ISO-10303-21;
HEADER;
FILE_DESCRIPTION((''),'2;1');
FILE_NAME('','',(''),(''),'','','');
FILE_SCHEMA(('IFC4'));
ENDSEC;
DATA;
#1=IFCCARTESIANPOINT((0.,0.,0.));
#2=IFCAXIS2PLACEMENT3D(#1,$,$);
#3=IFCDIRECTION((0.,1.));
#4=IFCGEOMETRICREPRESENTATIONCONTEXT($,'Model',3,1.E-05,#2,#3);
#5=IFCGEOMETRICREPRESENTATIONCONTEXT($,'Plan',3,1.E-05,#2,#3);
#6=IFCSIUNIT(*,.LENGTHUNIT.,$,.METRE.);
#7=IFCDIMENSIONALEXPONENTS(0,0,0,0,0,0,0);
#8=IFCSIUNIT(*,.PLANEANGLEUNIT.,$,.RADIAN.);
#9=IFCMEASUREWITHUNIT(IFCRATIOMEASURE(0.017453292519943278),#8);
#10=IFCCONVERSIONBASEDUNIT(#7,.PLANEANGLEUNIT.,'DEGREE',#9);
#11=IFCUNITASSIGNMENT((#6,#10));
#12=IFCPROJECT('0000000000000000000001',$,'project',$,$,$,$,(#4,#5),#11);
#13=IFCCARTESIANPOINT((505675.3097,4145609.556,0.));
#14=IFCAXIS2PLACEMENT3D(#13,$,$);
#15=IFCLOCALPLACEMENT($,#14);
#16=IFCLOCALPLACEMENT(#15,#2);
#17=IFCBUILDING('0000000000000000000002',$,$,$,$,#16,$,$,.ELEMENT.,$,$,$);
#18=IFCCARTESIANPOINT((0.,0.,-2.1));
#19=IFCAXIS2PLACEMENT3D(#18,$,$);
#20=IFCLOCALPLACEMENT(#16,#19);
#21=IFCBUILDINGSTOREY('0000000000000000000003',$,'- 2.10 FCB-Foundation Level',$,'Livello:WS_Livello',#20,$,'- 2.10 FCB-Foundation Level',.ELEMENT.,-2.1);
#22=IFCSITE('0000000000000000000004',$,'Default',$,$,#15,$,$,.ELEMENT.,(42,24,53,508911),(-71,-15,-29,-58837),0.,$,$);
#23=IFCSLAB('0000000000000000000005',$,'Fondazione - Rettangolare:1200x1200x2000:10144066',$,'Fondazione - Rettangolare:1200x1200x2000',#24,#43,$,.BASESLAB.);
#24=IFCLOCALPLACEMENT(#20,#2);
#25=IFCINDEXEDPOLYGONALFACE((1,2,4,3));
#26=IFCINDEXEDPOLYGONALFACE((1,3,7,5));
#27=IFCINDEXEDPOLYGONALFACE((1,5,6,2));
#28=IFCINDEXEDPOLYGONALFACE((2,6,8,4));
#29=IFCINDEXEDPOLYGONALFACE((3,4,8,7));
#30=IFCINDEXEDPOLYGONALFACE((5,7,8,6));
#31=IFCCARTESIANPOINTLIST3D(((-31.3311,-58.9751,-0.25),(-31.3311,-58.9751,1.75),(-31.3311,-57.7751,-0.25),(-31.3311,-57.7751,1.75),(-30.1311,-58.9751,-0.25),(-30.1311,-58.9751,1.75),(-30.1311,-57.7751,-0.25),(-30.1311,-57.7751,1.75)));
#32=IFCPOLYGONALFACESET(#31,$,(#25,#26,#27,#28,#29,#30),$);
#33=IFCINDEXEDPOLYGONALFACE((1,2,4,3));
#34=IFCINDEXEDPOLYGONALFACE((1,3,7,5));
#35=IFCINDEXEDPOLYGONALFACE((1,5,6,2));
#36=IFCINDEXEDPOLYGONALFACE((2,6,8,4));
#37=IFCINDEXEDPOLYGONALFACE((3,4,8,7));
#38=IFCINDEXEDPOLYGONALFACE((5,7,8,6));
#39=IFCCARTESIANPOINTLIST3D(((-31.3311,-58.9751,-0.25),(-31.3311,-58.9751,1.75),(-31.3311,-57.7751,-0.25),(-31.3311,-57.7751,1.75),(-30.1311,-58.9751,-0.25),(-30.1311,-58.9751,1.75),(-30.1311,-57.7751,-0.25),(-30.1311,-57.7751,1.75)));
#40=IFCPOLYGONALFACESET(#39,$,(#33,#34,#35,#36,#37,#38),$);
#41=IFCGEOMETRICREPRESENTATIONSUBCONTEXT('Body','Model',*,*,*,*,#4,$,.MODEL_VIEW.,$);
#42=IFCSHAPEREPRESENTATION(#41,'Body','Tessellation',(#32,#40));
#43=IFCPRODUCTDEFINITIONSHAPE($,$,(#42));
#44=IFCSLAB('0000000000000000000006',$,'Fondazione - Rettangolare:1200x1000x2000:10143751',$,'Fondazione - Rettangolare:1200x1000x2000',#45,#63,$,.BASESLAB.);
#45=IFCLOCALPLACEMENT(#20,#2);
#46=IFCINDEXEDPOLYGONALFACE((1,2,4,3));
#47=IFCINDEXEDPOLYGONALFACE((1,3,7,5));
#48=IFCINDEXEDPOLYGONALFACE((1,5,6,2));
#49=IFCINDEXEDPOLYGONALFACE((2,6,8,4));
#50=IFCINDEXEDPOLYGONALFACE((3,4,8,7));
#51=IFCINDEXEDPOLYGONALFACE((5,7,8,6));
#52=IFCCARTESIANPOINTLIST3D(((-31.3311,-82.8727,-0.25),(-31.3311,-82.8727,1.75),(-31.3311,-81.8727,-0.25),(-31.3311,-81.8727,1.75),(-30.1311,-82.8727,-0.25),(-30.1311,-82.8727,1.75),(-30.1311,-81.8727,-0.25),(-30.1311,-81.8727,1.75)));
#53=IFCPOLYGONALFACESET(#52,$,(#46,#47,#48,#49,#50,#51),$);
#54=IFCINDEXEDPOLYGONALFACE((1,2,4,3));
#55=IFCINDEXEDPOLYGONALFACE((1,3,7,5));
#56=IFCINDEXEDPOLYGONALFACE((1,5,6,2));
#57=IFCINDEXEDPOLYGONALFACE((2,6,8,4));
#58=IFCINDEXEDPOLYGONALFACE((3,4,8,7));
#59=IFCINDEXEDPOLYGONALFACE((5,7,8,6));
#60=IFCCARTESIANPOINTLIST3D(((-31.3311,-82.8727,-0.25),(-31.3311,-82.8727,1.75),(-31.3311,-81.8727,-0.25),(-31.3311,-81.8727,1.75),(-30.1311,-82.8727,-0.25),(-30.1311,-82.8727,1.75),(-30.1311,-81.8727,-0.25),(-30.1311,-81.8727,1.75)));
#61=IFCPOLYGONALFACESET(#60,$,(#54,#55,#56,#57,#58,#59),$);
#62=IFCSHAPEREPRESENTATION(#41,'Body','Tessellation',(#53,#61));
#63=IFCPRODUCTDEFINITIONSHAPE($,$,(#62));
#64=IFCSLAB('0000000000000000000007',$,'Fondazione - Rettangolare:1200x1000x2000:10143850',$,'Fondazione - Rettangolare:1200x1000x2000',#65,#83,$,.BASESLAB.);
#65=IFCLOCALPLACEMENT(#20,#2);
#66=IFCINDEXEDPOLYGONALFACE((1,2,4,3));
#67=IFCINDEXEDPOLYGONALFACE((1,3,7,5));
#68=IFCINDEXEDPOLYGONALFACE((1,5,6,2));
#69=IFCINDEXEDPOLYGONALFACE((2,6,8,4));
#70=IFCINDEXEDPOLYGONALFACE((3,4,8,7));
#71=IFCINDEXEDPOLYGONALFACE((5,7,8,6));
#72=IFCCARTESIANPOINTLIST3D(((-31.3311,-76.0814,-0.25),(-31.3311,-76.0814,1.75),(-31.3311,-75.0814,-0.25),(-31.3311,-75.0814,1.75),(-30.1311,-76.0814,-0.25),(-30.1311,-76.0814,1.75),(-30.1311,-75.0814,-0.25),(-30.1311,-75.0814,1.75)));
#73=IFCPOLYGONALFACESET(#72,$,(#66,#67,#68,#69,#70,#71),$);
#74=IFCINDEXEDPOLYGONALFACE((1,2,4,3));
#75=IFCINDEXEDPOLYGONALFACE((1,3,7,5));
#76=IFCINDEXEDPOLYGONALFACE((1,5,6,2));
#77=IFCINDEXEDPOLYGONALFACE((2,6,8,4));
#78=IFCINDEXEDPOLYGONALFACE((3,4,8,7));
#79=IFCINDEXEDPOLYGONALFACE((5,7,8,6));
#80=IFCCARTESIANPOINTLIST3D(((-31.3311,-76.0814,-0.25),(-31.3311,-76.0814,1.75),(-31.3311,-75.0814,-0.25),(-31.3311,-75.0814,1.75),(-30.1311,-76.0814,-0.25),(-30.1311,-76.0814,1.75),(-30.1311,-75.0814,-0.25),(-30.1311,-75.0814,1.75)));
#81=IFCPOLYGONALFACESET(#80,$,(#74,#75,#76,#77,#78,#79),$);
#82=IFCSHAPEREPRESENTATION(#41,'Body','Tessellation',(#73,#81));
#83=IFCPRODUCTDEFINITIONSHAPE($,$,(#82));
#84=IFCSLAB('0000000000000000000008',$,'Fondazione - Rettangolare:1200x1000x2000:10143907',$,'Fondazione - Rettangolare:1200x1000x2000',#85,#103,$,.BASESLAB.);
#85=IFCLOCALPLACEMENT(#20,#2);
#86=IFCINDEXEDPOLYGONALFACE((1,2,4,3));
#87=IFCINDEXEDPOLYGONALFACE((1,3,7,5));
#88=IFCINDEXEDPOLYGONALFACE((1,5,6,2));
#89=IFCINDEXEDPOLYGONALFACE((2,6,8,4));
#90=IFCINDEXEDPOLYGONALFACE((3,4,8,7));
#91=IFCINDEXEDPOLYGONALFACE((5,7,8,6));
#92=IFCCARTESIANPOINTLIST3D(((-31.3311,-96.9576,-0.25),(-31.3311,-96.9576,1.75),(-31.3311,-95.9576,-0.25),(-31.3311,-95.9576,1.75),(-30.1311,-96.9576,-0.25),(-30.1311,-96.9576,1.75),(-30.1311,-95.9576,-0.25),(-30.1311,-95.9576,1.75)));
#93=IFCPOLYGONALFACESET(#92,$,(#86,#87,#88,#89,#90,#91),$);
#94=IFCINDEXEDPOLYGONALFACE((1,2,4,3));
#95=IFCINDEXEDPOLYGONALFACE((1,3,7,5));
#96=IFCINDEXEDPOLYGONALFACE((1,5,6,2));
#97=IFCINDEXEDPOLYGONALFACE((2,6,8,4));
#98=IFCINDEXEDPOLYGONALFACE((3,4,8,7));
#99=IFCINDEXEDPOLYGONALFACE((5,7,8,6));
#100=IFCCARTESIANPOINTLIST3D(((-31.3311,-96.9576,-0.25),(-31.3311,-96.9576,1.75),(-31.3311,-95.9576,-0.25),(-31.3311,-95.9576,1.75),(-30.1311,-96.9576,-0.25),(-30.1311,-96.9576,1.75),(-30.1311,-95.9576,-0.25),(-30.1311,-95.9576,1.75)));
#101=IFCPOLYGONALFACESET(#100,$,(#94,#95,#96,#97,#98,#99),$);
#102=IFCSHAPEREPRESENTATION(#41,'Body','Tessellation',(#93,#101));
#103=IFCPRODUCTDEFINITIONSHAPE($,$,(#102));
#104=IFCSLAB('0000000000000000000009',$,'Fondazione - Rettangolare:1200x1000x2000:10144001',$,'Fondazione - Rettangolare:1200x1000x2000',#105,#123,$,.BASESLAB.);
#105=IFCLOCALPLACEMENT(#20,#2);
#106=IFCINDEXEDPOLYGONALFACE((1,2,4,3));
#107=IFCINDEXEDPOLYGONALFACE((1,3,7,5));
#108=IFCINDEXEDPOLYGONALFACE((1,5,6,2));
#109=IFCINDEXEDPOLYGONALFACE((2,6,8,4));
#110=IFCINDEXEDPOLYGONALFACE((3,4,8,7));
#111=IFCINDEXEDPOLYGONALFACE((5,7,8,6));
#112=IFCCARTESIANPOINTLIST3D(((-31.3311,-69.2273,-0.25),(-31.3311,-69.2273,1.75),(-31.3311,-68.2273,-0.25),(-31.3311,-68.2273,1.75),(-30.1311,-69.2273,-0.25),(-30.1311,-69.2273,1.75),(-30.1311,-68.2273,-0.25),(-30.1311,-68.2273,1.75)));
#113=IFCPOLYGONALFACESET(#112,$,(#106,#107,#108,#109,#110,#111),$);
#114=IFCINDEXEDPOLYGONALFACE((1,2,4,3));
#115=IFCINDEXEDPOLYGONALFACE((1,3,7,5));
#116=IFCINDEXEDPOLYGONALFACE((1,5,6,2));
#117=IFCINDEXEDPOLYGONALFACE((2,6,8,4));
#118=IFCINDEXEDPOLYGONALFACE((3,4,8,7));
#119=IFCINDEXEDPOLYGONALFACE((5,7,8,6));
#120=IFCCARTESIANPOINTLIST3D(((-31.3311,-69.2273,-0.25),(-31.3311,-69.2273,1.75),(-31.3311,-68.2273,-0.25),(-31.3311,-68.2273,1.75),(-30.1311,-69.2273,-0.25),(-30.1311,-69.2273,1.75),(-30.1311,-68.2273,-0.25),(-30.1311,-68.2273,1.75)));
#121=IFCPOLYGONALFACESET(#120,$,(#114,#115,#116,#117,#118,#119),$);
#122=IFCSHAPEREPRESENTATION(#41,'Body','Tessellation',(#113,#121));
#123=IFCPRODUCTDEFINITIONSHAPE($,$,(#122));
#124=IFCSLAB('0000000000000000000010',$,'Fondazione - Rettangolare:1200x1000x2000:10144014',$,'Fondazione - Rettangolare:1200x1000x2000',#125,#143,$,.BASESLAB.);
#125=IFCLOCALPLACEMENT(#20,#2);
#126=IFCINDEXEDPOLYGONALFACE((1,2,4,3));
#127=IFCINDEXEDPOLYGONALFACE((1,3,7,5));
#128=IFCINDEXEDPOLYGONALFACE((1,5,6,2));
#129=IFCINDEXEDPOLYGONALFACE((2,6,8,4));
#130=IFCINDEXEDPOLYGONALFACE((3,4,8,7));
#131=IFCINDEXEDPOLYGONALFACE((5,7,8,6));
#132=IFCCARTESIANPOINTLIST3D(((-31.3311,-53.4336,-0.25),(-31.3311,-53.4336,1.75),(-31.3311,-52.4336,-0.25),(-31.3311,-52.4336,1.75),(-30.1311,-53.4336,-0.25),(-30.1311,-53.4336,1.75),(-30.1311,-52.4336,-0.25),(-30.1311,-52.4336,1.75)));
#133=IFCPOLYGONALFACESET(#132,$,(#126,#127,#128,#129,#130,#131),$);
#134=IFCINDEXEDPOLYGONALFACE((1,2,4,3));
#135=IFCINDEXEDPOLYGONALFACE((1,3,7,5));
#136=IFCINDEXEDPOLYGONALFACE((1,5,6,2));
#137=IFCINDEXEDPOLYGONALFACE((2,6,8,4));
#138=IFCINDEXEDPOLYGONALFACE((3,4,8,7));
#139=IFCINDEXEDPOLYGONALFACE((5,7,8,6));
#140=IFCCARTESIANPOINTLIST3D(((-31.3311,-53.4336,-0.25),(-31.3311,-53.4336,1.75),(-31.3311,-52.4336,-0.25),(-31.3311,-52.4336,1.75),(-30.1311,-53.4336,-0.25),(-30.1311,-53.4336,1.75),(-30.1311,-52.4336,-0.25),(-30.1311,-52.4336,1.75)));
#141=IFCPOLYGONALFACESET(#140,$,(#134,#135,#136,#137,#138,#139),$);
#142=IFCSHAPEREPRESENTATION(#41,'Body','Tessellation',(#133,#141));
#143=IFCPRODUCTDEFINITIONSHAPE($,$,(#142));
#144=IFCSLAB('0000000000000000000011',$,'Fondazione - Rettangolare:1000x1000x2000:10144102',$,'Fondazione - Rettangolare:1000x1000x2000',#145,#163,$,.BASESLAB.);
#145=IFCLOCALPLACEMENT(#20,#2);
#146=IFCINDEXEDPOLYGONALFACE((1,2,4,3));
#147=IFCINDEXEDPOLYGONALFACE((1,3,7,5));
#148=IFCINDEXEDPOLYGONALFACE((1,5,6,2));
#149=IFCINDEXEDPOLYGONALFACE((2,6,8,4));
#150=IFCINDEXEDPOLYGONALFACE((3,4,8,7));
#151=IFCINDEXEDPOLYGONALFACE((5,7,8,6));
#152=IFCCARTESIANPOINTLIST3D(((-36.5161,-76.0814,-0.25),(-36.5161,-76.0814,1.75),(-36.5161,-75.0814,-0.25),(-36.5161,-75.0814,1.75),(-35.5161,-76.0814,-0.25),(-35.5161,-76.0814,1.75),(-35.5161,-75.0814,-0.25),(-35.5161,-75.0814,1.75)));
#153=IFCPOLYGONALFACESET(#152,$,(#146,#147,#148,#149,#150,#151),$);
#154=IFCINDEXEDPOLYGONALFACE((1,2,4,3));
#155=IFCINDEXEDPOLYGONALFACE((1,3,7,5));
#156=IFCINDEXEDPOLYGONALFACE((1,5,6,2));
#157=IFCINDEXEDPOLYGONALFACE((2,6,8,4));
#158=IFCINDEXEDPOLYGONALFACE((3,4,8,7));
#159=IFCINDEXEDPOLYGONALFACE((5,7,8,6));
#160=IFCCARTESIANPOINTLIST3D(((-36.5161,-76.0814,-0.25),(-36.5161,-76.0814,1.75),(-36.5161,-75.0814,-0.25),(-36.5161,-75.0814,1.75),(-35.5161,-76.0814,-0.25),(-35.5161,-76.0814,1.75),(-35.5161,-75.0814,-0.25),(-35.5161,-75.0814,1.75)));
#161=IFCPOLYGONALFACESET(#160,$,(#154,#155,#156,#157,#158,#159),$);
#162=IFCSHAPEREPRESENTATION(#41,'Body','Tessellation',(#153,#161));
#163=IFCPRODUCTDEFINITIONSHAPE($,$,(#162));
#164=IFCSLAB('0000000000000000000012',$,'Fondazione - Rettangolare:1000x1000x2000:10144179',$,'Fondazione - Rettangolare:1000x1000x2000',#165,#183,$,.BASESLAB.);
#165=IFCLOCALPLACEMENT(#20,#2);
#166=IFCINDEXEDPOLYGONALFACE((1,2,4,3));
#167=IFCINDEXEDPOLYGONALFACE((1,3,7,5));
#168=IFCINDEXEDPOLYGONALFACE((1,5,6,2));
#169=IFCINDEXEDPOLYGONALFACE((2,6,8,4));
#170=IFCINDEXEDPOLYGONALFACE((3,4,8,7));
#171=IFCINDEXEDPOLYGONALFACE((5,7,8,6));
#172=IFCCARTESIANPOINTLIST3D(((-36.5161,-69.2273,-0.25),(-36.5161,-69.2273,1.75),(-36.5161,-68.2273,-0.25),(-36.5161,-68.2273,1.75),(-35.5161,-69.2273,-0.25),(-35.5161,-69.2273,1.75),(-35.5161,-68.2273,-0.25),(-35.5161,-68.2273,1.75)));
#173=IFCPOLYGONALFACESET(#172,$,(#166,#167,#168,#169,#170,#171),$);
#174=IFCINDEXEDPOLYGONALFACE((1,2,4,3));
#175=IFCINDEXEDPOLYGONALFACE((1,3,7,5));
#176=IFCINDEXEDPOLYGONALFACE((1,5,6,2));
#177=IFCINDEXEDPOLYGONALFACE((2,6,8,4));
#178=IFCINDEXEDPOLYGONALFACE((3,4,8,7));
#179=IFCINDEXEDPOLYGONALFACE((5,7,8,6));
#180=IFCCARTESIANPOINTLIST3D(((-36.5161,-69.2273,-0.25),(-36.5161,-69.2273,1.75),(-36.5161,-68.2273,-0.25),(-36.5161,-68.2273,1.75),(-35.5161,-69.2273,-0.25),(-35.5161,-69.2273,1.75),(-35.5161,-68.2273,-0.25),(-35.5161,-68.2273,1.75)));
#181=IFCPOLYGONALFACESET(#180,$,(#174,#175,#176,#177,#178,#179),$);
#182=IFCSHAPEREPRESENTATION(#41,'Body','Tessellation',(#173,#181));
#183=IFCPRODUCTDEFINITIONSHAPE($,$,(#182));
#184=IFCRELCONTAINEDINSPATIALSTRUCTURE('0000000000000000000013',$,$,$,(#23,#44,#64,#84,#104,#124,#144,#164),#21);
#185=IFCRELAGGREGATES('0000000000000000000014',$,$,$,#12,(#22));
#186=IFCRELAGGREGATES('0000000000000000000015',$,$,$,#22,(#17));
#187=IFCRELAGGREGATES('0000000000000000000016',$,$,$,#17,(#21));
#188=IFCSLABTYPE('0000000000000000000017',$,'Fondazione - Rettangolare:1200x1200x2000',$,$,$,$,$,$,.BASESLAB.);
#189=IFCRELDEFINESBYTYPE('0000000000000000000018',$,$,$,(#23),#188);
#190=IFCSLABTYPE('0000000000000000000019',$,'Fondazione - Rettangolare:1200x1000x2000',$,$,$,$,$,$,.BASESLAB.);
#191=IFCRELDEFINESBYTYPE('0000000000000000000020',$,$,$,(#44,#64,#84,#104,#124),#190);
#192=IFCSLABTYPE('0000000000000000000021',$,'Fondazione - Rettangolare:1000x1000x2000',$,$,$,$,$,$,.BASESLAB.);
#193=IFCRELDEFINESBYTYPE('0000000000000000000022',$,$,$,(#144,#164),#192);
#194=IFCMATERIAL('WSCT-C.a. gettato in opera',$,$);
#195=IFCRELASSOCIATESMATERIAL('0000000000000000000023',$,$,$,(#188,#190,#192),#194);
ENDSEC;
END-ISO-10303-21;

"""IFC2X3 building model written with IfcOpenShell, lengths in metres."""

from ifc_helpers import new_model, entity, si_unit, converted_unit, direction, frame, frame_2d, origin, origin_2d_with_axis, place, context, subcontext, project, spatial, rectangle, extrude, material, type_object, element, save


model = new_model("IFC2X3")

# Units and contexts
model_context = context("Model", 3, precision=1e-05, world=origin(), true_north=direction((0.0, 1.0)))
plan_context = context("Plan", 3, precision=1e-05, world=origin(), true_north=direction((0.0, 1.0)))
body_context = subcontext(model_context, "Body", "Model", "MODEL_VIEW")
ifc_project = project(units=[si_unit("LENGTHUNIT", "METRE"), converted_unit("PLANEANGLEUNIT", "DEGREE", entity("IfcRatioMeasure", 0.017453292519943278), si_unit("PLANEANGLEUNIT", "RADIAN"), dimensions=[0, 0, 0, 0, 0, 0, 0])], contexts=[model_context, plan_context])

# Site, building, storey
site_placement = place(None, frame((505675.3097, 4145609.556, 0.0)))
site = spatial("IfcSite", under=ifc_project, at=site_placement, Name="Default", CompositionType="ELEMENT", RefLatitude=(42, 24, 53, 508911), RefLongitude=(-71, -15, -29, -58837), RefElevation=0.0)
building_placement = place(site_placement, origin())
building = spatial("IfcBuilding", under=site, at=building_placement, CompositionType="ELEMENT")
storey_placement = place(building_placement, frame((0.0, 0.0, -2.1)))
storey = spatial("IfcBuildingStorey", under=building, at=storey_placement, Name="- 2.10 FCB-Foundation Level", ObjectType="Livello:WS_Livello", LongName="- 2.10 FCB-Foundation Level", CompositionType="ELEMENT", Elevation=-2.1)

# Slabs
ifc_material_1 = material(Name="WSCT-C.a. gettato in opera")
slab_type_1 = type_object("IfcSlabType", Name="Fondazione - Rettangolare:1200x1200x2000", PredefinedType="BASESLAB", material=ifc_material_1)
slab_1_placement = place(storey_placement, origin())
element("IfcSlab", 1, at=slab_1_placement, inside=storey, type_object=slab_type_1, Name="Fondazione - Rettangolare:1200x1200x2000:10144066", ObjectType="Fondazione - Rettangolare:1200x1200x2000", PredefinedType="BASESLAB", context=body_context, shape_type="SweptSolid", body=[
    extrude(rectangle(XDim=1.2, YDim=1.2, at=frame_2d((0.0, 0.0), x_axis=(1.0, 0.0))), frame((-30.7311, -58.3751, -0.25), z_axis=(0.0, 0.0, 1.0), x_axis=(-1.0, 0.0, 0.0)), (0.0, 0.0, 1.0), 2.0),
    extrude(rectangle(XDim=1.2, YDim=1.2, at=frame_2d((0.0, 0.0), x_axis=(1.0, 0.0))), frame((-30.7311, -58.3751, -0.25), z_axis=(0.0, 0.0, 1.0), x_axis=(-1.0, 0.0, 0.0)), (0.0, 0.0, 1.0), 2.0),
])
slab_type_2 = type_object("IfcSlabType", Name="Fondazione - Rettangolare:1200x1000x2000", PredefinedType="BASESLAB", material=ifc_material_1)
slab_2_placement = place(storey_placement, origin())
element("IfcSlab", 2, at=slab_2_placement, inside=storey, type_object=slab_type_2, Name="Fondazione - Rettangolare:1200x1000x2000:10143751", ObjectType="Fondazione - Rettangolare:1200x1000x2000", PredefinedType="BASESLAB", context=body_context, shape_type="SweptSolid", body=[
    extrude(rectangle(XDim=1.2, YDim=1.0, at=frame_2d((0.0, 0.0), x_axis=(1.0, 0.0))), frame((-30.7311, -82.3727, -0.25), z_axis=(0.0, 0.0, 1.0), x_axis=(-1.0, 0.0, 0.0)), (0.0, 0.0, 1.0), 2.0),
    extrude(rectangle(XDim=1.2, YDim=1.0, at=frame_2d((0.0, 0.0), x_axis=(1.0, 0.0))), frame((-30.7311, -82.3727, -0.25), z_axis=(0.0, 0.0, 1.0), x_axis=(-1.0, 0.0, 0.0)), (0.0, 0.0, 1.0), 2.0),
])
slab_3_placement = place(storey_placement, origin())
element("IfcSlab", 3, at=slab_3_placement, inside=storey, type_object=slab_type_2, Name="Fondazione - Rettangolare:1200x1000x2000:10143850", ObjectType="Fondazione - Rettangolare:1200x1000x2000", PredefinedType="BASESLAB", context=body_context, shape_type="SweptSolid", body=[
    extrude(rectangle(XDim=1.2, YDim=1.0, at=frame_2d((0.0, 0.0), x_axis=(1.0, 0.0))), frame((-30.7311, -75.5814, -0.25), z_axis=(0.0, 0.0, 1.0), x_axis=(-1.0, 0.0, 0.0)), (0.0, 0.0, 1.0), 2.0),
    extrude(rectangle(XDim=1.2, YDim=1.0, at=frame_2d((0.0, 0.0), x_axis=(1.0, 0.0))), frame((-30.7311, -75.5814, -0.25), z_axis=(0.0, 0.0, 1.0), x_axis=(-1.0, 0.0, 0.0)), (0.0, 0.0, 1.0), 2.0),
])
slab_4_placement = place(storey_placement, origin())
element("IfcSlab", 4, at=slab_4_placement, inside=storey, type_object=slab_type_2, Name="Fondazione - Rettangolare:1200x1000x2000:10143907", ObjectType="Fondazione - Rettangolare:1200x1000x2000", PredefinedType="BASESLAB", context=body_context, shape_type="SweptSolid", body=[
    extrude(rectangle(XDim=1.2, YDim=1.0, at=frame_2d((0.0, 0.0), x_axis=(1.0, 0.0))), frame((-30.7311, -96.4576, -0.25), z_axis=(0.0, 0.0, 1.0), x_axis=(-1.0, 0.0, 0.0)), (0.0, 0.0, 1.0), 2.0),
    extrude(rectangle(XDim=1.2, YDim=1.0, at=frame_2d((0.0, 0.0), x_axis=(1.0, 0.0))), frame((-30.7311, -96.4576, -0.25), z_axis=(0.0, 0.0, 1.0), x_axis=(-1.0, 0.0, 0.0)), (0.0, 0.0, 1.0), 2.0),
])
slab_5_placement = place(storey_placement, origin())
element("IfcSlab", 5, at=slab_5_placement, inside=storey, type_object=slab_type_2, Name="Fondazione - Rettangolare:1200x1000x2000:10144001", ObjectType="Fondazione - Rettangolare:1200x1000x2000", PredefinedType="BASESLAB", context=body_context, shape_type="SweptSolid", body=[
    extrude(rectangle(XDim=1.2, YDim=1.0, at=frame_2d((0.0, 0.0), x_axis=(1.0, 0.0))), frame((-30.7311, -68.7273, -0.25), z_axis=(0.0, 0.0, 1.0), x_axis=(-1.0, 0.0, 0.0)), (0.0, 0.0, 1.0), 2.0),
    extrude(rectangle(XDim=1.2, YDim=1.0, at=frame_2d((0.0, 0.0), x_axis=(1.0, 0.0))), frame((-30.7311, -68.7273, -0.25), z_axis=(0.0, 0.0, 1.0), x_axis=(-1.0, 0.0, 0.0)), (0.0, 0.0, 1.0), 2.0),
])
slab_6_placement = place(storey_placement, origin())
element("IfcSlab", 6, at=slab_6_placement, inside=storey, type_object=slab_type_2, Name="Fondazione - Rettangolare:1200x1000x2000:10144014", ObjectType="Fondazione - Rettangolare:1200x1000x2000", PredefinedType="BASESLAB", context=body_context, shape_type="SweptSolid", body=[
    extrude(rectangle(XDim=1.2, YDim=1.0, at=frame_2d((0.0, 0.0), x_axis=(1.0, 0.0))), frame((-30.7311, -52.9336, -0.25), z_axis=(0.0, 0.0, 1.0), x_axis=(-1.0, 0.0, 0.0)), (0.0, 0.0, 1.0), 2.0),
    extrude(rectangle(XDim=1.2, YDim=1.0, at=frame_2d((0.0, 0.0), x_axis=(1.0, 0.0))), frame((-30.7311, -52.9336, -0.25), z_axis=(0.0, 0.0, 1.0), x_axis=(-1.0, 0.0, 0.0)), (0.0, 0.0, 1.0), 2.0),
])
slab_type_3 = type_object("IfcSlabType", Name="Fondazione - Rettangolare:1000x1000x2000", PredefinedType="BASESLAB", material=ifc_material_1)
slab_7_placement = place(storey_placement, origin())
element("IfcSlab", 7, at=slab_7_placement, inside=storey, type_object=slab_type_3, Name="Fondazione - Rettangolare:1000x1000x2000:10144102", ObjectType="Fondazione - Rettangolare:1000x1000x2000", PredefinedType="BASESLAB", context=body_context, shape_type="SweptSolid", body=[
    extrude(rectangle(XDim=1.0, YDim=1.0, at=origin_2d_with_axis()), frame((-36.0161, -75.5814, -0.25), z_axis=(0.0, 0.0, 1.0), x_axis=(-1.0, 0.0, 0.0)), (0.0, 0.0, 1.0), 2.0),
    extrude(rectangle(XDim=1.0, YDim=1.0, at=origin_2d_with_axis()), frame((-36.0161, -75.5814, -0.25), z_axis=(0.0, 0.0, 1.0), x_axis=(-1.0, 0.0, 0.0)), (0.0, 0.0, 1.0), 2.0),
])
slab_8_placement = place(storey_placement, origin())
element("IfcSlab", 8, at=slab_8_placement, inside=storey, type_object=slab_type_3, Name="Fondazione - Rettangolare:1000x1000x2000:10144179", ObjectType="Fondazione - Rettangolare:1000x1000x2000", PredefinedType="BASESLAB", context=body_context, shape_type="SweptSolid", body=[
    extrude(rectangle(XDim=1.0, YDim=1.0, at=origin_2d_with_axis()), frame((-36.0161, -68.7273, -0.25), z_axis=(0.0, 0.0, 1.0), x_axis=(-1.0, 0.0, 0.0)), (0.0, 0.0, 1.0), 2.0),
    extrude(rectangle(XDim=1.0, YDim=1.0, at=origin_2d_with_axis()), frame((-36.0161, -68.7273, -0.25), z_axis=(0.0, 0.0, 1.0), x_axis=(-1.0, 0.0, 0.0)), (0.0, 0.0, 1.0), 2.0),
])

save(model, "model.ifc")
